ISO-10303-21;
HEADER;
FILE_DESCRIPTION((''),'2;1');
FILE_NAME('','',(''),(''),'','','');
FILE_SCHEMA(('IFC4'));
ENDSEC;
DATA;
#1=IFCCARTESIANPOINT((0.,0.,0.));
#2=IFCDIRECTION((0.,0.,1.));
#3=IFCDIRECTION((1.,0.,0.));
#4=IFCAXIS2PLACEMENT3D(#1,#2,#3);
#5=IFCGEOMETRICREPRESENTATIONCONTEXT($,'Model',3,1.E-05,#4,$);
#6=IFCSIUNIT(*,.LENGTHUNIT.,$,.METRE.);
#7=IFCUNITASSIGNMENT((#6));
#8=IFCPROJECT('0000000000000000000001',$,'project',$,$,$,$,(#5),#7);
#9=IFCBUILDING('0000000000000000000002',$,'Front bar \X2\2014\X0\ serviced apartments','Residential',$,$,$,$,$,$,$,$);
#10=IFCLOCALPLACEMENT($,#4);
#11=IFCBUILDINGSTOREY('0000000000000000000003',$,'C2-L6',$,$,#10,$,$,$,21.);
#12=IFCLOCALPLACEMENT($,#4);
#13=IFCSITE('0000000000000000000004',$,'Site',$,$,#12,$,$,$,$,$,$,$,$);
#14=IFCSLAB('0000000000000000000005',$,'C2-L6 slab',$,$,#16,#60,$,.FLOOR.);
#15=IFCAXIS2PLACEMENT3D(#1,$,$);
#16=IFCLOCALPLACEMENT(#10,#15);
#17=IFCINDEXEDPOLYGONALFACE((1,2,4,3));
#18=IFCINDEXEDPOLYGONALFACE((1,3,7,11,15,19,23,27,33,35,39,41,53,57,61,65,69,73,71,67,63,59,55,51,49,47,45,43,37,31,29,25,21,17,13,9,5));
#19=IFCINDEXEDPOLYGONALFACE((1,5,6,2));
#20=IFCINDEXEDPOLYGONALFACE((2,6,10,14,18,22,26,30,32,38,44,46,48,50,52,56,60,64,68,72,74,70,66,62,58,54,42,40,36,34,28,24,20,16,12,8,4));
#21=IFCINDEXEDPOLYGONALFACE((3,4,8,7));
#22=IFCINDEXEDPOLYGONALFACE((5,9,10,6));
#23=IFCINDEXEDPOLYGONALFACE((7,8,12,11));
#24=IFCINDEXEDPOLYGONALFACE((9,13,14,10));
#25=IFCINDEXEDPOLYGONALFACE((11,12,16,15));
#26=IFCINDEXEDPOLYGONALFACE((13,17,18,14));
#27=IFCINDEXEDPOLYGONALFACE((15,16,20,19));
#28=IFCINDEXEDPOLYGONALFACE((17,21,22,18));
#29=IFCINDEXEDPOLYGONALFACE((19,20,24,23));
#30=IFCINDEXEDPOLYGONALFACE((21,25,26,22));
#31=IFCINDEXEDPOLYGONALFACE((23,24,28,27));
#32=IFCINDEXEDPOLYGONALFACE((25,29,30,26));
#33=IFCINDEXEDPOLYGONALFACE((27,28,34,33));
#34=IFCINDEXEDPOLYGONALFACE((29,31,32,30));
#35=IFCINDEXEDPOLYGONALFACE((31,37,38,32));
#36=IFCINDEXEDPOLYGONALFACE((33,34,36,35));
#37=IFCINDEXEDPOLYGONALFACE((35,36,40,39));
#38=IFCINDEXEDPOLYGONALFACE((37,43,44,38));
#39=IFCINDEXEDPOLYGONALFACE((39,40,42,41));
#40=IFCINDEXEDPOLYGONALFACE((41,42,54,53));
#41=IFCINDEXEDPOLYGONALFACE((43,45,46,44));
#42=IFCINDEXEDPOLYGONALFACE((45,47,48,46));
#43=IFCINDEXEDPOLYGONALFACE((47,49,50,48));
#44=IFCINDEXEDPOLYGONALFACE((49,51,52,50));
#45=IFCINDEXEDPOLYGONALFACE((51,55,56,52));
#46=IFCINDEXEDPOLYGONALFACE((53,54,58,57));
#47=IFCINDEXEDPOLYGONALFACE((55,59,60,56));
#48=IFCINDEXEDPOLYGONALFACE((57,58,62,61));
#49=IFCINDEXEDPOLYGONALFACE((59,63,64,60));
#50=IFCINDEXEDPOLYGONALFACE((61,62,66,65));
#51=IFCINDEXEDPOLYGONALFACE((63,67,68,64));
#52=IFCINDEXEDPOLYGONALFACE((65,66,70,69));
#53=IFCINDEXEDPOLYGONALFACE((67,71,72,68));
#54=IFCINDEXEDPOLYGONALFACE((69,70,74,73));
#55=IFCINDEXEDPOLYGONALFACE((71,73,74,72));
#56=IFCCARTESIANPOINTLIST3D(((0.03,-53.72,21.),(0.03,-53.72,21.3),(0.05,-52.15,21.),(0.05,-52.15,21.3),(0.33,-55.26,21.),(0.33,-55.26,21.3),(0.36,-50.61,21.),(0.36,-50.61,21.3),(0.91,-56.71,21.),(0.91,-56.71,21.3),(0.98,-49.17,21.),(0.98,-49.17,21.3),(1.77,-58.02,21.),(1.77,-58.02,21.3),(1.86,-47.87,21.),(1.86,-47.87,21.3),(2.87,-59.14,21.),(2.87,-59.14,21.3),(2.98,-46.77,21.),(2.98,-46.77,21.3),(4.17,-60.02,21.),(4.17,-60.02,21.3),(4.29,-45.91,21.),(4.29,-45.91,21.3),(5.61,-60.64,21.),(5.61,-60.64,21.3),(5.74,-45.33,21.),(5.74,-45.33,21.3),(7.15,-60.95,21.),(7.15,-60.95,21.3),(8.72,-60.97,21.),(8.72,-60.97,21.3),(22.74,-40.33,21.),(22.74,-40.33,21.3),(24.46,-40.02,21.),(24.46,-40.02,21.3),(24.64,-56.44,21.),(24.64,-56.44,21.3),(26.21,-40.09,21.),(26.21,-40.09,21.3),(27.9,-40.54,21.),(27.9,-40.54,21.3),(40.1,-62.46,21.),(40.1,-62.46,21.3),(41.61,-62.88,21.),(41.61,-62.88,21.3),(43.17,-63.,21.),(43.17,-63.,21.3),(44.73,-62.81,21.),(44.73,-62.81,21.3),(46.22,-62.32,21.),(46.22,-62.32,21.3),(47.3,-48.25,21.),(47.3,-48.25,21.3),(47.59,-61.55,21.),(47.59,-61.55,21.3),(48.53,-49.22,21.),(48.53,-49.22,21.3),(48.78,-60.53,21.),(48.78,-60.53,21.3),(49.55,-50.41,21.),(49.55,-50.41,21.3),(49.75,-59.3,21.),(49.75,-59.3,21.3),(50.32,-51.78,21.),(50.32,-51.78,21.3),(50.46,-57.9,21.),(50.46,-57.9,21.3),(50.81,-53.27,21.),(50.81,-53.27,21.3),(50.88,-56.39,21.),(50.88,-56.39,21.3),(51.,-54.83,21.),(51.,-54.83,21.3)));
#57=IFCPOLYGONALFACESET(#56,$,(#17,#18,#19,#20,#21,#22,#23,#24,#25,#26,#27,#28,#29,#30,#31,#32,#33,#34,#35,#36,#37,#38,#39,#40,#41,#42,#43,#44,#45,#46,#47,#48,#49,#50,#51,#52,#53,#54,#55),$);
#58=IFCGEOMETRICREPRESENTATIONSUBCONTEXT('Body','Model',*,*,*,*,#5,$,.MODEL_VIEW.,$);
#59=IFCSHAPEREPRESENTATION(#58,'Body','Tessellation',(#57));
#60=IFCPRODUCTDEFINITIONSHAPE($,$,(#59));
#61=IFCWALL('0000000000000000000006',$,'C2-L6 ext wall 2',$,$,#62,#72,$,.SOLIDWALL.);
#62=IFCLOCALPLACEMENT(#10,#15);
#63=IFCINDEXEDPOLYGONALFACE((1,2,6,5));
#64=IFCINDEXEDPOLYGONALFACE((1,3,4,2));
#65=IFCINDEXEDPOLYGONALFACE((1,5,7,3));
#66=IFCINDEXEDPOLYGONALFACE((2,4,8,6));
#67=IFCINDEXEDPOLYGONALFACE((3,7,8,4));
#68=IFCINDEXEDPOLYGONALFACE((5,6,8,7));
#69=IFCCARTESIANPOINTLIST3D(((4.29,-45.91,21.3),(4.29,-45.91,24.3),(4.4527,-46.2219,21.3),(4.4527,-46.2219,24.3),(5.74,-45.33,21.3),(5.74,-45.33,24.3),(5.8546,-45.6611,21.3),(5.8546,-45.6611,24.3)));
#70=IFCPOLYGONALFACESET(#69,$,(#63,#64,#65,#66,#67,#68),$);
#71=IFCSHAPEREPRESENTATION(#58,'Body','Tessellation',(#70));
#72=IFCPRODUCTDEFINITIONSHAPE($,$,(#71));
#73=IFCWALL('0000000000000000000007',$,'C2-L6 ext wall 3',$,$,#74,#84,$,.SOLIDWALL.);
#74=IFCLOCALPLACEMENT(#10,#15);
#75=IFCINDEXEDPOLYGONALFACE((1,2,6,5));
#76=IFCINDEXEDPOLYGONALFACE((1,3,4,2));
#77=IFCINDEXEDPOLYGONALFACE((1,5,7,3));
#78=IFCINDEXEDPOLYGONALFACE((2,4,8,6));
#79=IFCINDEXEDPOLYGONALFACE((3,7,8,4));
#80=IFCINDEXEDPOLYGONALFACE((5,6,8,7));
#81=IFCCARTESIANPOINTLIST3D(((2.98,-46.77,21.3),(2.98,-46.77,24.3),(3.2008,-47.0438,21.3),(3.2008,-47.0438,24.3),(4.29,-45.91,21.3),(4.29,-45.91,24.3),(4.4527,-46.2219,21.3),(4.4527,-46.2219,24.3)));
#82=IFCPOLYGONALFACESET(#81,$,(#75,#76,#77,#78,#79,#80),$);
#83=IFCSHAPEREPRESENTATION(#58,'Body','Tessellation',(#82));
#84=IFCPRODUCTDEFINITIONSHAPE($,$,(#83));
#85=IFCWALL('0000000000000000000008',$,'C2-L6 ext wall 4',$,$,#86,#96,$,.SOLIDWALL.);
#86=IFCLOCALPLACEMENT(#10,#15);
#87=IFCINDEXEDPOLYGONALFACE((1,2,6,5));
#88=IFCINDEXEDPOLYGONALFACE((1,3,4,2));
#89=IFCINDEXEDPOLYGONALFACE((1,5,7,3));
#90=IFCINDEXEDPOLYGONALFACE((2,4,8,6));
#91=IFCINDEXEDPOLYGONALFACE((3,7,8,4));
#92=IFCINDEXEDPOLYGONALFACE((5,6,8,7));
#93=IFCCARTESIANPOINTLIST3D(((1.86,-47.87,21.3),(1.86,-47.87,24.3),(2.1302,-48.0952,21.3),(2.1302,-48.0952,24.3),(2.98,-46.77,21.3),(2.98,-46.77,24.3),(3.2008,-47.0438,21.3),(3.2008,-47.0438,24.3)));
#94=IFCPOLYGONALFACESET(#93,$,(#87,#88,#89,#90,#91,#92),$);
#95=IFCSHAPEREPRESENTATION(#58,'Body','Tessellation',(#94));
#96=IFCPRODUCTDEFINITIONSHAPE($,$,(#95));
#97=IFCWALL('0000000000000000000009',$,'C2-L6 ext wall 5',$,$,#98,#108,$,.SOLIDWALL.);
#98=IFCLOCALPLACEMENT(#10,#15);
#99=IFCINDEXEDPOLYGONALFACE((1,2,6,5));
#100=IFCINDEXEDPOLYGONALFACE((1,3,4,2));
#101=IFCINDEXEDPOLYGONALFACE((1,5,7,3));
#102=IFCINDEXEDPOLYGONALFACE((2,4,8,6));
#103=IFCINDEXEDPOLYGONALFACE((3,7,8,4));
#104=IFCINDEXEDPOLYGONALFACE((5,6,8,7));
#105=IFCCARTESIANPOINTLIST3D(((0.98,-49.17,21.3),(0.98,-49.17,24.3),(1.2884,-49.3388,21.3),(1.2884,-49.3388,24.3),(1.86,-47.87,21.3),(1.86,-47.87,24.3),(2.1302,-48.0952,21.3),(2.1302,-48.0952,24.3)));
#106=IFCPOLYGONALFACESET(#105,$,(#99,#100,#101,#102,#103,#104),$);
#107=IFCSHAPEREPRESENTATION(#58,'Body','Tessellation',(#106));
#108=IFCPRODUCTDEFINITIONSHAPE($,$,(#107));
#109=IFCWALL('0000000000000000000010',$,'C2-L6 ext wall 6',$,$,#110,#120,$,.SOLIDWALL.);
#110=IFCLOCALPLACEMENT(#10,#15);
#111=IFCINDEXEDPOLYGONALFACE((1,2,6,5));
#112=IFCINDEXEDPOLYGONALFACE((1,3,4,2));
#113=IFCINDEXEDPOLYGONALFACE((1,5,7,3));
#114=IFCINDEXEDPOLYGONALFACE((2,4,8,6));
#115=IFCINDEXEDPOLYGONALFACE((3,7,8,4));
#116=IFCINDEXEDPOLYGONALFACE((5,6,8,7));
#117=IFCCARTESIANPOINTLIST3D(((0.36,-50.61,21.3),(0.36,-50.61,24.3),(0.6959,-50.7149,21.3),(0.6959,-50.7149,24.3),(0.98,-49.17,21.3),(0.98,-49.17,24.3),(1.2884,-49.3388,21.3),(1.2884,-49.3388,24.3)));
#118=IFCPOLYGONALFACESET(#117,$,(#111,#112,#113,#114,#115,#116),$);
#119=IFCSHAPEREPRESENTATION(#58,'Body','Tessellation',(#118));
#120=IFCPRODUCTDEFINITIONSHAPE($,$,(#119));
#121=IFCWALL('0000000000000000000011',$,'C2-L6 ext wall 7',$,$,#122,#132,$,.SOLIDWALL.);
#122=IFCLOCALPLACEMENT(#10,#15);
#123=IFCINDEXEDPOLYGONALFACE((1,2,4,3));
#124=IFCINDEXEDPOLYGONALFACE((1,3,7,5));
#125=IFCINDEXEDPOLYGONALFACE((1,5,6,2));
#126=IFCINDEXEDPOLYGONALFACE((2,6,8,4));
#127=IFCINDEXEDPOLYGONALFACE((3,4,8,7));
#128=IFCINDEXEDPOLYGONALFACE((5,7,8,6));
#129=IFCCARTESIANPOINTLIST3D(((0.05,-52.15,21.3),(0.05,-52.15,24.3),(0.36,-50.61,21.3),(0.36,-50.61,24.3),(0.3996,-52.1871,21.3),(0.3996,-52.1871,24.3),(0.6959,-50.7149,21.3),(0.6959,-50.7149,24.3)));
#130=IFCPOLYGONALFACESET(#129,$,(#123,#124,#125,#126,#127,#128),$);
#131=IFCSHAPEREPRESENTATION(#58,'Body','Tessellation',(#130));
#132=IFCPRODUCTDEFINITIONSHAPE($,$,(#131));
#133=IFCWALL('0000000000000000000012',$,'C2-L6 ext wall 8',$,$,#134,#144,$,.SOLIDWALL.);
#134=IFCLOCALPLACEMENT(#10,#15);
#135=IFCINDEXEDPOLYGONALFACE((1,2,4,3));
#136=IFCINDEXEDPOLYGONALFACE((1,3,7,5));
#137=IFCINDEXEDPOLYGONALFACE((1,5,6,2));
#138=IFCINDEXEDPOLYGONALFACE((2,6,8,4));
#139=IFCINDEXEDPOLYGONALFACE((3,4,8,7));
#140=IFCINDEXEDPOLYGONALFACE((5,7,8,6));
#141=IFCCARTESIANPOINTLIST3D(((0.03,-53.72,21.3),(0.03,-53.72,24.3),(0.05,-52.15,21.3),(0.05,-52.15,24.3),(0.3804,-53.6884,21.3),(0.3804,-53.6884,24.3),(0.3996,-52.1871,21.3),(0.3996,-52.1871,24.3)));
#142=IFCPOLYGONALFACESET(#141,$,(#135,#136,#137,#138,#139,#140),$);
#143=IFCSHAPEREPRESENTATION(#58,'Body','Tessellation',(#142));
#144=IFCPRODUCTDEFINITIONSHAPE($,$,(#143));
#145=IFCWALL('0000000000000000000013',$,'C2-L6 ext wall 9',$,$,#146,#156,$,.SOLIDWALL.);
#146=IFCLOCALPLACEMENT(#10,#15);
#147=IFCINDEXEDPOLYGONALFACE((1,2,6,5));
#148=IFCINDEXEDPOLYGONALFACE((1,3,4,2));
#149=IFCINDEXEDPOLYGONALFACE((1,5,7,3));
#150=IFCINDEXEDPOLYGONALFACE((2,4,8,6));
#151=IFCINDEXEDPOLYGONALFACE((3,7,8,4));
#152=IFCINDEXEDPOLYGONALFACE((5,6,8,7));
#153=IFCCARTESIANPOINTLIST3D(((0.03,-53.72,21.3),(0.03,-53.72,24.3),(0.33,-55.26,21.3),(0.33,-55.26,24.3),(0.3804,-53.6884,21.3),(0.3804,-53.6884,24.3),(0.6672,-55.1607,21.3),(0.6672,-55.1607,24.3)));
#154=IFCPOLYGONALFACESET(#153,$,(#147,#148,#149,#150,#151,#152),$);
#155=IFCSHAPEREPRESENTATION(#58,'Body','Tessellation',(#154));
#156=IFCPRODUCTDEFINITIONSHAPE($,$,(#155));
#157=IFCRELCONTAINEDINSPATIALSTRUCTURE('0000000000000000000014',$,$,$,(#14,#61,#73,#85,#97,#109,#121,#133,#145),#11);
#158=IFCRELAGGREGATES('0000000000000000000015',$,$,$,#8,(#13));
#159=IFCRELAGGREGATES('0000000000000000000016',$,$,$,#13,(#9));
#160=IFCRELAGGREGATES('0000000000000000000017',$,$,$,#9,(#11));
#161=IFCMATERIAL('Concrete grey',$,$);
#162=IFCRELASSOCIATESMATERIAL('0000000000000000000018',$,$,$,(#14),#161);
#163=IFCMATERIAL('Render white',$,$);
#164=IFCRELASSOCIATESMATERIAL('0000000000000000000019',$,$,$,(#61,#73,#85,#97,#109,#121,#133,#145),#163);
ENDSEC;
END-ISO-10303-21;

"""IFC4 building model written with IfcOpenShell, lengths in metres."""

from ifc_helpers import new_model, si_unit, frame, origin_with_axes, place, context, subcontext, project, spatial, polyline, outline, extrude, material, element, save


model = new_model("IFC4")

# Units and contexts
model_context = context("Model", 3, precision=1e-05, world=origin_with_axes())
body_context = subcontext(model_context, "Body", "Model", "MODEL_VIEW")
ifc_project = project(units=[si_unit("LENGTHUNIT", "METRE")], contexts=[model_context])

# Site, building, storey
site_placement = place(None, origin_with_axes())
site = spatial("IfcSite", under=ifc_project, at=site_placement, Name="Site")
building = spatial("IfcBuilding", under=site, Name="Front bar — serviced apartments", Description="Residential")
storey_placement = place(None, origin_with_axes())
storey = spatial("IfcBuildingStorey", under=building, at=storey_placement, Name="C2-L6", Elevation=21.0)

# Slab
ifc_material_1 = material(Name="Concrete grey")
slab_placement = place(storey_placement, origin_with_axes())
element("IfcSlab", 1, at=slab_placement, inside=storey, material=ifc_material_1, Name="C2-L6 slab", PredefinedType="FLOOR", context=body_context, shape_type="SweptSolid", body=[
    extrude(outline(polyline([(22.74, -40.33), (5.74, -45.33), (4.29, -45.91), (2.98, -46.77), (1.86, -47.87), (0.98, -49.17), (0.36, -50.61), (0.05, -52.15), (0.03, -53.72), (0.33, -55.26), (0.91, -56.71), (1.77, -58.02), (2.87, -59.14), (4.17, -60.02), (5.61, -60.64), (7.15, -60.95), (8.72, -60.97), (24.64, -56.44), (40.1, -62.46), (41.61, -62.88), (43.17, -63.0), (44.73, -62.81), (46.22, -62.32), (47.59, -61.55), (48.78, -60.53), (49.75, -59.3), (50.46, -57.9), (50.88, -56.39), (51.0, -54.83), (50.81, -53.27), (50.32, -51.78), (49.55, -50.41), (48.53, -49.22), (47.3, -48.25), (27.9, -40.54), (26.21, -40.09), (24.46, -40.02), (22.74, -40.33)])), frame((0.0, 0.0, 21.0), z_axis=(0.0, 0.0, 1.0), x_axis=(1.0, 0.0, 0.0)), (0.0, 0.0, 1.0), 0.3),
])

# Shared definitions
ifc_material_2 = material(Name="Render white")

# Walls
wall_1_placement = place(storey_placement, origin_with_axes())
element("IfcWall", 2, at=wall_1_placement, inside=storey, material=ifc_material_2, Name="C2-L6 ext wall 2", PredefinedType="SOLIDWALL", context=body_context, shape_type="SweptSolid", body=[
    extrude(outline(polyline([(5.74, -45.33), (4.29, -45.91), (4.4527, -46.2219), (5.8546, -45.6611), (5.74, -45.33)])), frame((0.0, 0.0, 21.3), z_axis=(0.0, 0.0, 1.0), x_axis=(1.0, 0.0, 0.0)), (0.0, 0.0, 1.0), 3.0),
])
wall_2_placement = place(storey_placement, origin_with_axes())
element("IfcWall", 3, at=wall_2_placement, inside=storey, material=ifc_material_2, Name="C2-L6 ext wall 3", PredefinedType="SOLIDWALL", context=body_context, shape_type="SweptSolid", body=[
    extrude(outline(polyline([(4.29, -45.91), (2.98, -46.77), (3.2008, -47.0438), (4.4527, -46.2219), (4.29, -45.91)])), frame((0.0, 0.0, 21.3), z_axis=(0.0, 0.0, 1.0), x_axis=(1.0, 0.0, 0.0)), (0.0, 0.0, 1.0), 3.0),
])
wall_3_placement = place(storey_placement, origin_with_axes())
element("IfcWall", 4, at=wall_3_placement, inside=storey, material=ifc_material_2, Name="C2-L6 ext wall 4", PredefinedType="SOLIDWALL", context=body_context, shape_type="SweptSolid", body=[
    extrude(outline(polyline([(2.98, -46.77), (1.86, -47.87), (2.1302, -48.0952), (3.2008, -47.0438), (2.98, -46.77)])), frame((0.0, 0.0, 21.3), z_axis=(0.0, 0.0, 1.0), x_axis=(1.0, 0.0, 0.0)), (0.0, 0.0, 1.0), 3.0),
])
wall_4_placement = place(storey_placement, origin_with_axes())
element("IfcWall", 5, at=wall_4_placement, inside=storey, material=ifc_material_2, Name="C2-L6 ext wall 5", PredefinedType="SOLIDWALL", context=body_context, shape_type="SweptSolid", body=[
    extrude(outline(polyline([(1.86, -47.87), (0.98, -49.17), (1.2884, -49.3388), (2.1302, -48.0952), (1.86, -47.87)])), frame((0.0, 0.0, 21.3), z_axis=(0.0, 0.0, 1.0), x_axis=(1.0, 0.0, 0.0)), (0.0, 0.0, 1.0), 3.0),
])
wall_5_placement = place(storey_placement, origin_with_axes())
element("IfcWall", 6, at=wall_5_placement, inside=storey, material=ifc_material_2, Name="C2-L6 ext wall 6", PredefinedType="SOLIDWALL", context=body_context, shape_type="SweptSolid", body=[
    extrude(outline(polyline([(0.98, -49.17), (0.36, -50.61), (0.6959, -50.7149), (1.2884, -49.3388), (0.98, -49.17)])), frame((0.0, 0.0, 21.3), z_axis=(0.0, 0.0, 1.0), x_axis=(1.0, 0.0, 0.0)), (0.0, 0.0, 1.0), 3.0),
])
wall_6_placement = place(storey_placement, origin_with_axes())
element("IfcWall", 7, at=wall_6_placement, inside=storey, material=ifc_material_2, Name="C2-L6 ext wall 7", PredefinedType="SOLIDWALL", context=body_context, shape_type="SweptSolid", body=[
    extrude(outline(polyline([(0.36, -50.61), (0.05, -52.15), (0.3996, -52.1871), (0.6959, -50.7149), (0.36, -50.61)])), frame((0.0, 0.0, 21.3), z_axis=(0.0, 0.0, 1.0), x_axis=(1.0, 0.0, 0.0)), (0.0, 0.0, 1.0), 3.0),
])
wall_7_placement = place(storey_placement, origin_with_axes())
element("IfcWall", 8, at=wall_7_placement, inside=storey, material=ifc_material_2, Name="C2-L6 ext wall 8", PredefinedType="SOLIDWALL", context=body_context, shape_type="SweptSolid", body=[
    extrude(outline(polyline([(0.05, -52.15), (0.03, -53.72), (0.3804, -53.6884), (0.3996, -52.1871), (0.05, -52.15)])), frame((0.0, 0.0, 21.3), z_axis=(0.0, 0.0, 1.0), x_axis=(1.0, 0.0, 0.0)), (0.0, 0.0, 1.0), 3.0),
])
wall_8_placement = place(storey_placement, origin_with_axes())
element("IfcWall", 9, at=wall_8_placement, inside=storey, material=ifc_material_2, Name="C2-L6 ext wall 9", PredefinedType="SOLIDWALL", context=body_context, shape_type="SweptSolid", body=[
    extrude(outline(polyline([(0.03, -53.72), (0.33, -55.26), (0.6672, -55.1607), (0.3804, -53.6884), (0.03, -53.72)])), frame((0.0, 0.0, 21.3), z_axis=(0.0, 0.0, 1.0), x_axis=(1.0, 0.0, 0.0)), (0.0, 0.0, 1.0), 3.0),
])

save(model, "model.ifc")
